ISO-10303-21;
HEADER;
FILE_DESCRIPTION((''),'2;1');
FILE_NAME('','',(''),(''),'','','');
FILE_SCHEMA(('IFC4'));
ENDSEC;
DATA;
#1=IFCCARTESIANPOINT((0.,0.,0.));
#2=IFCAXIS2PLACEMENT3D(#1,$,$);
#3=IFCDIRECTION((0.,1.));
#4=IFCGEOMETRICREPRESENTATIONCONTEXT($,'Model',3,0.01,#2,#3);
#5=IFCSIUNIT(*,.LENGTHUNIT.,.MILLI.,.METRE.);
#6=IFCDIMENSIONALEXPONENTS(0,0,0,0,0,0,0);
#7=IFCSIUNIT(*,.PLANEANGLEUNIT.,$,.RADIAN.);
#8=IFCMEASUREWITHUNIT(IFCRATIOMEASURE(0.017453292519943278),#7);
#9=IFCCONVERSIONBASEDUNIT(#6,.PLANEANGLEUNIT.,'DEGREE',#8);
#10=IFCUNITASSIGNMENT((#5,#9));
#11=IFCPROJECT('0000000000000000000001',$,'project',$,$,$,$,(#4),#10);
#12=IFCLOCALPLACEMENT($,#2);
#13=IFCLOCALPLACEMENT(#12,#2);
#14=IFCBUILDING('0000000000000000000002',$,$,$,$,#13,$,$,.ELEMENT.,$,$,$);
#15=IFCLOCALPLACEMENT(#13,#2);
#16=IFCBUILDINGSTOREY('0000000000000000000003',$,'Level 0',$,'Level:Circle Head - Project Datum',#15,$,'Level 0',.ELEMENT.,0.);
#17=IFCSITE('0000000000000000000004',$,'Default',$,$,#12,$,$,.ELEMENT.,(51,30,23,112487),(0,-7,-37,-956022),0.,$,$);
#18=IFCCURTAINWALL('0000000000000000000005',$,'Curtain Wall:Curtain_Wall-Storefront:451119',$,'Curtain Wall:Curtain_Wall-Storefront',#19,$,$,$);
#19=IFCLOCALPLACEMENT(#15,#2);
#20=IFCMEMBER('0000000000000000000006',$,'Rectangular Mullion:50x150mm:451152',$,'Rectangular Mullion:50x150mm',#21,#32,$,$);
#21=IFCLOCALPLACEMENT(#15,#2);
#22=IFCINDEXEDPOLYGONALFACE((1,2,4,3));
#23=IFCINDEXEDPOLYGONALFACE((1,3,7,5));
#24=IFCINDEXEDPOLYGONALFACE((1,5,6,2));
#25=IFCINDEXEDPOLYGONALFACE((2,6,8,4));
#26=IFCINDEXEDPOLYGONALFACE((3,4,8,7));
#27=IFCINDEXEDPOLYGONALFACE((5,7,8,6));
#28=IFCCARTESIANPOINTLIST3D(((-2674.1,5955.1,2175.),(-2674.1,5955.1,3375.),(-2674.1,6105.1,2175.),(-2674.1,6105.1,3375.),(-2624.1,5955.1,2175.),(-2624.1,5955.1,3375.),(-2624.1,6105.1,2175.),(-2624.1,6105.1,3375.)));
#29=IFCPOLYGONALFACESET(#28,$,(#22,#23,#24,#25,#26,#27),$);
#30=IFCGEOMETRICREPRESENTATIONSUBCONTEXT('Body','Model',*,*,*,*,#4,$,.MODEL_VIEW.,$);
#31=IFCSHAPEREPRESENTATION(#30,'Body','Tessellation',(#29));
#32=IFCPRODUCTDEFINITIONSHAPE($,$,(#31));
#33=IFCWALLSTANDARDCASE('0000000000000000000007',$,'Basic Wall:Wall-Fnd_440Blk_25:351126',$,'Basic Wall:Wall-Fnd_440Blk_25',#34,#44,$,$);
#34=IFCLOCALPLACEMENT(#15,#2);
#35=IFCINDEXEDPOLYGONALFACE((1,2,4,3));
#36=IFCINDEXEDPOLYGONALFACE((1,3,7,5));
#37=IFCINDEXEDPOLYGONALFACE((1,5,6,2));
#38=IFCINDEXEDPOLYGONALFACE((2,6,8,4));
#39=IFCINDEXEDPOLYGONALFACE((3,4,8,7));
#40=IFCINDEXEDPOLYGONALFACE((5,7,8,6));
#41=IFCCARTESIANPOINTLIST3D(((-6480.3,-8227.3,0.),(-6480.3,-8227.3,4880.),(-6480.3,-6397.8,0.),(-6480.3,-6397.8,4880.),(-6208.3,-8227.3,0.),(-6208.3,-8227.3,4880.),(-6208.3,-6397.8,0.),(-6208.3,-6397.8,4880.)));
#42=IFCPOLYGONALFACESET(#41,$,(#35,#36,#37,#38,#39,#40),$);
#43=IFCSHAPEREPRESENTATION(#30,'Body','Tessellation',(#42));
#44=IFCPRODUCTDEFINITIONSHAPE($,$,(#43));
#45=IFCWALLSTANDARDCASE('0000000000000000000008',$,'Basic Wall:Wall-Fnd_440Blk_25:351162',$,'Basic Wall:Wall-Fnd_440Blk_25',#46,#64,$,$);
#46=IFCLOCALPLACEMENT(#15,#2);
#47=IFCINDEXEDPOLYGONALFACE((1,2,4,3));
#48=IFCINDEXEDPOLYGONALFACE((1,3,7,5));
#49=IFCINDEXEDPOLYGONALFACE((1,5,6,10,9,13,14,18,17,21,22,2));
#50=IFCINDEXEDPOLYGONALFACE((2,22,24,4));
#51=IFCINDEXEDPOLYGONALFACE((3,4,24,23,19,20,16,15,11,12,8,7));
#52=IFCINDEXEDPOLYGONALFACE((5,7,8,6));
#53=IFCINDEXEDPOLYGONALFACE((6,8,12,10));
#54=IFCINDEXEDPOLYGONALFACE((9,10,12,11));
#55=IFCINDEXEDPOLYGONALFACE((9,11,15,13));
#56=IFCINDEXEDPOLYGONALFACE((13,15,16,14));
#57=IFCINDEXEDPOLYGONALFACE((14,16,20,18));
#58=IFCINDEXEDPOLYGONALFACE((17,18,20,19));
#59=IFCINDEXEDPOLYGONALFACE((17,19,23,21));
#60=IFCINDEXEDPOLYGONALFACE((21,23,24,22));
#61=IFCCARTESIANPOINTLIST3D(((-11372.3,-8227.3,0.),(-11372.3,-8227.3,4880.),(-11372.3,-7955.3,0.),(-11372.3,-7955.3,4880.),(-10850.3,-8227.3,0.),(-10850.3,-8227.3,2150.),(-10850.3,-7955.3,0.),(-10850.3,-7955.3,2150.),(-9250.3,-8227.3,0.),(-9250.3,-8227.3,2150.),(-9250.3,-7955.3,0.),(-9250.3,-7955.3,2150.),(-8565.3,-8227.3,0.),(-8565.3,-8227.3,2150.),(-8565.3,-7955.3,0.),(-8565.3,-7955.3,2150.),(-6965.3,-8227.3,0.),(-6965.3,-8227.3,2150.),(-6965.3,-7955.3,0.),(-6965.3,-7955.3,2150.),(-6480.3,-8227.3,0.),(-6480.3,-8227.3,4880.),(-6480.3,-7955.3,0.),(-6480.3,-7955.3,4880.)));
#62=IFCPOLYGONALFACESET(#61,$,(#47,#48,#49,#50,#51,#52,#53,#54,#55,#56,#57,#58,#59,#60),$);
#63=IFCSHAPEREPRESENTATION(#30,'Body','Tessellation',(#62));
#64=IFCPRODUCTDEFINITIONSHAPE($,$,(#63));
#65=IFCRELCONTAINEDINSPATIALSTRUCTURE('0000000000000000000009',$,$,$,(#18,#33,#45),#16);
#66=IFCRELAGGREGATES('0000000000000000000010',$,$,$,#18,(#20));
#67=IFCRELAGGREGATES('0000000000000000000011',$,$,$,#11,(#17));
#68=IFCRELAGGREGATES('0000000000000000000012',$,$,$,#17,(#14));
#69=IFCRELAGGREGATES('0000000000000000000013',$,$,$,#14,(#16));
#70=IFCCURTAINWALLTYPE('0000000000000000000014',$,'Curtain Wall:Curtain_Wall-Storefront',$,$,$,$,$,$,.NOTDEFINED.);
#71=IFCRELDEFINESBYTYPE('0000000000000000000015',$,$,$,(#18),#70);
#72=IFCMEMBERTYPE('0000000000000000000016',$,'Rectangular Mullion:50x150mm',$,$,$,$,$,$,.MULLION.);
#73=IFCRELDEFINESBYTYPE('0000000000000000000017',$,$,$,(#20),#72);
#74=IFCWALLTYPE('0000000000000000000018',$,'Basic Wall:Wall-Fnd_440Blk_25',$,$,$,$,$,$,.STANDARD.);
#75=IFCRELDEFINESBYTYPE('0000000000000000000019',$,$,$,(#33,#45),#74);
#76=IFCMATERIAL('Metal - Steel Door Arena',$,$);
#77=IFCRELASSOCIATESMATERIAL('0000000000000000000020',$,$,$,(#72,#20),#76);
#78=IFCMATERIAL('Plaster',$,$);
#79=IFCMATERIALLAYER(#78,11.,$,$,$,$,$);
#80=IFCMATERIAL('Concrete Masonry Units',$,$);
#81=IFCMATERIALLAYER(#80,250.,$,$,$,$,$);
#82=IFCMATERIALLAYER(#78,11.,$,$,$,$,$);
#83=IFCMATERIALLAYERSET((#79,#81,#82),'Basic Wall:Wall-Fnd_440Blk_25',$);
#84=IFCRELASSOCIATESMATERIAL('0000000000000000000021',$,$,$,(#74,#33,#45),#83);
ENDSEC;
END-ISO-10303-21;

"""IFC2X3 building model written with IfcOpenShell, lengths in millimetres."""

from ifc_helpers import new_model, entity, si_unit, converted_unit, direction, frame, frame_2d, origin, origin_2d_with_axis, place, context, subcontext, project, spatial, polyline, rectangle, extrude, clip, bounded_halfspace, source, transform, mapped, material, layer, layer_set, layer_usage, type_object, type_shapes, element, aggregate, save


model = new_model("IFC2X3")

# Units and contexts
model_context = context("Model", 3, precision=0.01, world=origin(), true_north=direction((0.0, 1.0)))
body_context = subcontext(model_context, "Body", "Model", "MODEL_VIEW")
ifc_project = project(units=[si_unit("LENGTHUNIT", "METRE", prefix="MILLI"), converted_unit("PLANEANGLEUNIT", "DEGREE", entity("IfcRatioMeasure", 0.017453292519943278), si_unit("PLANEANGLEUNIT", "RADIAN"), dimensions=[0, 0, 0, 0, 0, 0, 0])], contexts=[model_context])

# Site, building, storey
site_placement = place(None, origin())
site = spatial("IfcSite", under=ifc_project, at=site_placement, Name="Default", CompositionType="ELEMENT", RefLatitude=(51, 30, 23, 112487), RefLongitude=(0, -7, -37, -956022), RefElevation=0.0)
building_placement = place(site_placement, origin())
building = spatial("IfcBuilding", under=site, at=building_placement, CompositionType="ELEMENT")
storey_placement = place(building_placement, origin())
storey = spatial("IfcBuildingStorey", under=building, at=storey_placement, Name="Level 0", ObjectType="Level:Circle Head - Project Datum", LongName="Level 0", CompositionType="ELEMENT", Elevation=0.0)

# Shared definitions
ifc_material_1 = material(Name="Plaster")

# Curtain wall, member
curtain_wall_type = type_object("IfcCurtainWallType", Name="Curtain Wall:Curtain_Wall-Storefront", PredefinedType="NOTDEFINED")
curtain_wall_placement = place(storey_placement, origin())
curtain_wall = element("IfcCurtainWall", 1, at=curtain_wall_placement, inside=storey, type_object=curtain_wall_type, Name="Curtain Wall:Curtain_Wall-Storefront:451119", ObjectType="Curtain Wall:Curtain_Wall-Storefront")
ifc_material_2 = material(Name="Metal - Steel Door Arena")
member_type_1 = type_object("IfcMemberType", Name="Rectangular Mullion:50x150mm", PredefinedType="MULLION", material=ifc_material_2)
shared_shape_1 = source(origin(), body_context, "Body", "SweptSolid", [
    extrude(rectangle(XDim=150.0, YDim=50.0, at=origin_2d_with_axis()), frame((0.0, 0.0, -1200.0), z_axis=(0.0, 0.0, 1.0), x_axis=(0.0, -1.0, 0.0)), (0.0, 0.0, 1.0), 1200.0),
])
type_shapes(member_type_1, [shared_shape_1])
member_1_placement = place(curtain_wall_placement, frame((-2649.1, 6030.1, 2175.0), z_axis=(0.0, 0.0, -1.0), x_axis=(-1.0, 0.0, 0.0)))
member_1 = element("IfcMember", 2, at=member_1_placement, type_object=member_type_1, material=ifc_material_2, Name="Rectangular Mullion:50x150mm:451152", ObjectType="Rectangular Mullion:50x150mm", context=body_context, shape_type="MappedRepresentation", body=[
    mapped(shared_shape_1, transform((0.0, 0.0, 0.0), scale=1.0)),
])

aggregate(curtain_wall, [member_1])

# Shared definitions
ifc_material_3 = material(Name="Concrete Masonry Units")

# Wall
ifc_layer_1 = layer(ifc_material_1, 11.0)
ifc_layer_2 = layer(ifc_material_3, 250.0)
ifc_layer_3 = layer(ifc_material_1, 11.0)
ifc_layer_set_1 = layer_set([ifc_layer_1, ifc_layer_2, ifc_layer_3], Name="Basic Wall:Wall-Fnd_440Blk_25")
ifc_layer_usage_1 = layer_usage(ifc_layer_set_1, "AXIS2", "NEGATIVE", 136.0)
wall_type_1 = type_object("IfcWallType", Name="Basic Wall:Wall-Fnd_440Blk_25", PredefinedType="STANDARD", material=ifc_layer_set_1)
wall_1_placement = place(storey_placement, frame((-6344.3, -6397.8, 0.0), z_axis=(0.0, 0.0, 1.0), x_axis=(0.0, -1.0, 0.0)))
element("IfcWallStandardCase", 3, at=wall_1_placement, inside=storey, type_object=wall_type_1, material=ifc_layer_usage_1, Name="Basic Wall:Wall-Fnd_440Blk_25:351126", ObjectType="Basic Wall:Wall-Fnd_440Blk_25", context=body_context, shape_type="SweptSolid", body=[
    extrude(rectangle(XDim=1829.5, YDim=272.0, at=frame_2d((914.8, 0.0), x_axis=(-1.0, 0.0))), origin(), (0.0, 0.0, 1.0), 4880.0),
])

# Wall, openings
ifc_layer_usage_2 = layer_usage(ifc_layer_set_1, "AXIS2", "NEGATIVE", 136.0)
wall_2_placement = place(storey_placement, frame((-6480.3, -8091.3, 0.0), z_axis=(0.0, 0.0, 1.0), x_axis=(-1.0, 0.0, 0.0)))
wall_2 = element("IfcWallStandardCase", 4, at=wall_2_placement, inside=storey, type_object=wall_type_1, material=ifc_layer_usage_2, Name="Basic Wall:Wall-Fnd_440Blk_25:351162", ObjectType="Basic Wall:Wall-Fnd_440Blk_25", context=body_context, shape_type="Clipping", body=[
    clip(extrude(rectangle(XDim=4892.0, YDim=272.0, at=frame_2d((2446.0, 0.0), x_axis=(1.0, 0.0))), origin(), (0.0, 0.0, 1.0), 4880.0), bounded_halfspace(frame((0.0, -136.0, 4880.0), z_axis=(0.0, 0.0, -1.0), x_axis=(-1.0, 0.0, 0.0)), True, frame((0.0, -136.0, 4880.0)), polyline([(0.0, 0.0), (1408176.0, 0.0), (1491081.6, 0.0), (1491081.6, 82905.6), (0.0, 82905.6), (0.0, 0.0)]))),
])
opening_1_placement = place(wall_2_placement, frame((2085.0, 136.0, 0.0)))
element("IfcOpeningElement", 5, at=opening_1_placement, cuts=wall_2, ObjectType="Opening", context=body_context, shape_type="SweptSolid", body=[
    extrude(rectangle(XDim=2150.0, YDim=1600.0, at=frame_2d((1075.0, 800.0), x_axis=(1.0, 0.0))), frame((0.0, 0.0, 0.0), z_axis=(0.0, -1.0, 0.0), x_axis=(0.0, 0.0, 1.0)), (0.0, 0.0, 1.0), 272.0),
])
opening_2_placement = place(wall_2_placement, frame((4370.0, 136.0, 0.0)))
element("IfcOpeningElement", 6, at=opening_2_placement, cuts=wall_2, ObjectType="Opening", context=body_context, shape_type="SweptSolid", body=[
    extrude(rectangle(XDim=2150.0, YDim=1600.0, at=frame_2d((1075.0, 800.0), x_axis=(1.0, 0.0))), frame((0.0, 0.0, 0.0), z_axis=(0.0, -1.0, 0.0), x_axis=(0.0, 0.0, 1.0)), (0.0, 0.0, 1.0), 272.0),
])

save(model, "model.ifc")
